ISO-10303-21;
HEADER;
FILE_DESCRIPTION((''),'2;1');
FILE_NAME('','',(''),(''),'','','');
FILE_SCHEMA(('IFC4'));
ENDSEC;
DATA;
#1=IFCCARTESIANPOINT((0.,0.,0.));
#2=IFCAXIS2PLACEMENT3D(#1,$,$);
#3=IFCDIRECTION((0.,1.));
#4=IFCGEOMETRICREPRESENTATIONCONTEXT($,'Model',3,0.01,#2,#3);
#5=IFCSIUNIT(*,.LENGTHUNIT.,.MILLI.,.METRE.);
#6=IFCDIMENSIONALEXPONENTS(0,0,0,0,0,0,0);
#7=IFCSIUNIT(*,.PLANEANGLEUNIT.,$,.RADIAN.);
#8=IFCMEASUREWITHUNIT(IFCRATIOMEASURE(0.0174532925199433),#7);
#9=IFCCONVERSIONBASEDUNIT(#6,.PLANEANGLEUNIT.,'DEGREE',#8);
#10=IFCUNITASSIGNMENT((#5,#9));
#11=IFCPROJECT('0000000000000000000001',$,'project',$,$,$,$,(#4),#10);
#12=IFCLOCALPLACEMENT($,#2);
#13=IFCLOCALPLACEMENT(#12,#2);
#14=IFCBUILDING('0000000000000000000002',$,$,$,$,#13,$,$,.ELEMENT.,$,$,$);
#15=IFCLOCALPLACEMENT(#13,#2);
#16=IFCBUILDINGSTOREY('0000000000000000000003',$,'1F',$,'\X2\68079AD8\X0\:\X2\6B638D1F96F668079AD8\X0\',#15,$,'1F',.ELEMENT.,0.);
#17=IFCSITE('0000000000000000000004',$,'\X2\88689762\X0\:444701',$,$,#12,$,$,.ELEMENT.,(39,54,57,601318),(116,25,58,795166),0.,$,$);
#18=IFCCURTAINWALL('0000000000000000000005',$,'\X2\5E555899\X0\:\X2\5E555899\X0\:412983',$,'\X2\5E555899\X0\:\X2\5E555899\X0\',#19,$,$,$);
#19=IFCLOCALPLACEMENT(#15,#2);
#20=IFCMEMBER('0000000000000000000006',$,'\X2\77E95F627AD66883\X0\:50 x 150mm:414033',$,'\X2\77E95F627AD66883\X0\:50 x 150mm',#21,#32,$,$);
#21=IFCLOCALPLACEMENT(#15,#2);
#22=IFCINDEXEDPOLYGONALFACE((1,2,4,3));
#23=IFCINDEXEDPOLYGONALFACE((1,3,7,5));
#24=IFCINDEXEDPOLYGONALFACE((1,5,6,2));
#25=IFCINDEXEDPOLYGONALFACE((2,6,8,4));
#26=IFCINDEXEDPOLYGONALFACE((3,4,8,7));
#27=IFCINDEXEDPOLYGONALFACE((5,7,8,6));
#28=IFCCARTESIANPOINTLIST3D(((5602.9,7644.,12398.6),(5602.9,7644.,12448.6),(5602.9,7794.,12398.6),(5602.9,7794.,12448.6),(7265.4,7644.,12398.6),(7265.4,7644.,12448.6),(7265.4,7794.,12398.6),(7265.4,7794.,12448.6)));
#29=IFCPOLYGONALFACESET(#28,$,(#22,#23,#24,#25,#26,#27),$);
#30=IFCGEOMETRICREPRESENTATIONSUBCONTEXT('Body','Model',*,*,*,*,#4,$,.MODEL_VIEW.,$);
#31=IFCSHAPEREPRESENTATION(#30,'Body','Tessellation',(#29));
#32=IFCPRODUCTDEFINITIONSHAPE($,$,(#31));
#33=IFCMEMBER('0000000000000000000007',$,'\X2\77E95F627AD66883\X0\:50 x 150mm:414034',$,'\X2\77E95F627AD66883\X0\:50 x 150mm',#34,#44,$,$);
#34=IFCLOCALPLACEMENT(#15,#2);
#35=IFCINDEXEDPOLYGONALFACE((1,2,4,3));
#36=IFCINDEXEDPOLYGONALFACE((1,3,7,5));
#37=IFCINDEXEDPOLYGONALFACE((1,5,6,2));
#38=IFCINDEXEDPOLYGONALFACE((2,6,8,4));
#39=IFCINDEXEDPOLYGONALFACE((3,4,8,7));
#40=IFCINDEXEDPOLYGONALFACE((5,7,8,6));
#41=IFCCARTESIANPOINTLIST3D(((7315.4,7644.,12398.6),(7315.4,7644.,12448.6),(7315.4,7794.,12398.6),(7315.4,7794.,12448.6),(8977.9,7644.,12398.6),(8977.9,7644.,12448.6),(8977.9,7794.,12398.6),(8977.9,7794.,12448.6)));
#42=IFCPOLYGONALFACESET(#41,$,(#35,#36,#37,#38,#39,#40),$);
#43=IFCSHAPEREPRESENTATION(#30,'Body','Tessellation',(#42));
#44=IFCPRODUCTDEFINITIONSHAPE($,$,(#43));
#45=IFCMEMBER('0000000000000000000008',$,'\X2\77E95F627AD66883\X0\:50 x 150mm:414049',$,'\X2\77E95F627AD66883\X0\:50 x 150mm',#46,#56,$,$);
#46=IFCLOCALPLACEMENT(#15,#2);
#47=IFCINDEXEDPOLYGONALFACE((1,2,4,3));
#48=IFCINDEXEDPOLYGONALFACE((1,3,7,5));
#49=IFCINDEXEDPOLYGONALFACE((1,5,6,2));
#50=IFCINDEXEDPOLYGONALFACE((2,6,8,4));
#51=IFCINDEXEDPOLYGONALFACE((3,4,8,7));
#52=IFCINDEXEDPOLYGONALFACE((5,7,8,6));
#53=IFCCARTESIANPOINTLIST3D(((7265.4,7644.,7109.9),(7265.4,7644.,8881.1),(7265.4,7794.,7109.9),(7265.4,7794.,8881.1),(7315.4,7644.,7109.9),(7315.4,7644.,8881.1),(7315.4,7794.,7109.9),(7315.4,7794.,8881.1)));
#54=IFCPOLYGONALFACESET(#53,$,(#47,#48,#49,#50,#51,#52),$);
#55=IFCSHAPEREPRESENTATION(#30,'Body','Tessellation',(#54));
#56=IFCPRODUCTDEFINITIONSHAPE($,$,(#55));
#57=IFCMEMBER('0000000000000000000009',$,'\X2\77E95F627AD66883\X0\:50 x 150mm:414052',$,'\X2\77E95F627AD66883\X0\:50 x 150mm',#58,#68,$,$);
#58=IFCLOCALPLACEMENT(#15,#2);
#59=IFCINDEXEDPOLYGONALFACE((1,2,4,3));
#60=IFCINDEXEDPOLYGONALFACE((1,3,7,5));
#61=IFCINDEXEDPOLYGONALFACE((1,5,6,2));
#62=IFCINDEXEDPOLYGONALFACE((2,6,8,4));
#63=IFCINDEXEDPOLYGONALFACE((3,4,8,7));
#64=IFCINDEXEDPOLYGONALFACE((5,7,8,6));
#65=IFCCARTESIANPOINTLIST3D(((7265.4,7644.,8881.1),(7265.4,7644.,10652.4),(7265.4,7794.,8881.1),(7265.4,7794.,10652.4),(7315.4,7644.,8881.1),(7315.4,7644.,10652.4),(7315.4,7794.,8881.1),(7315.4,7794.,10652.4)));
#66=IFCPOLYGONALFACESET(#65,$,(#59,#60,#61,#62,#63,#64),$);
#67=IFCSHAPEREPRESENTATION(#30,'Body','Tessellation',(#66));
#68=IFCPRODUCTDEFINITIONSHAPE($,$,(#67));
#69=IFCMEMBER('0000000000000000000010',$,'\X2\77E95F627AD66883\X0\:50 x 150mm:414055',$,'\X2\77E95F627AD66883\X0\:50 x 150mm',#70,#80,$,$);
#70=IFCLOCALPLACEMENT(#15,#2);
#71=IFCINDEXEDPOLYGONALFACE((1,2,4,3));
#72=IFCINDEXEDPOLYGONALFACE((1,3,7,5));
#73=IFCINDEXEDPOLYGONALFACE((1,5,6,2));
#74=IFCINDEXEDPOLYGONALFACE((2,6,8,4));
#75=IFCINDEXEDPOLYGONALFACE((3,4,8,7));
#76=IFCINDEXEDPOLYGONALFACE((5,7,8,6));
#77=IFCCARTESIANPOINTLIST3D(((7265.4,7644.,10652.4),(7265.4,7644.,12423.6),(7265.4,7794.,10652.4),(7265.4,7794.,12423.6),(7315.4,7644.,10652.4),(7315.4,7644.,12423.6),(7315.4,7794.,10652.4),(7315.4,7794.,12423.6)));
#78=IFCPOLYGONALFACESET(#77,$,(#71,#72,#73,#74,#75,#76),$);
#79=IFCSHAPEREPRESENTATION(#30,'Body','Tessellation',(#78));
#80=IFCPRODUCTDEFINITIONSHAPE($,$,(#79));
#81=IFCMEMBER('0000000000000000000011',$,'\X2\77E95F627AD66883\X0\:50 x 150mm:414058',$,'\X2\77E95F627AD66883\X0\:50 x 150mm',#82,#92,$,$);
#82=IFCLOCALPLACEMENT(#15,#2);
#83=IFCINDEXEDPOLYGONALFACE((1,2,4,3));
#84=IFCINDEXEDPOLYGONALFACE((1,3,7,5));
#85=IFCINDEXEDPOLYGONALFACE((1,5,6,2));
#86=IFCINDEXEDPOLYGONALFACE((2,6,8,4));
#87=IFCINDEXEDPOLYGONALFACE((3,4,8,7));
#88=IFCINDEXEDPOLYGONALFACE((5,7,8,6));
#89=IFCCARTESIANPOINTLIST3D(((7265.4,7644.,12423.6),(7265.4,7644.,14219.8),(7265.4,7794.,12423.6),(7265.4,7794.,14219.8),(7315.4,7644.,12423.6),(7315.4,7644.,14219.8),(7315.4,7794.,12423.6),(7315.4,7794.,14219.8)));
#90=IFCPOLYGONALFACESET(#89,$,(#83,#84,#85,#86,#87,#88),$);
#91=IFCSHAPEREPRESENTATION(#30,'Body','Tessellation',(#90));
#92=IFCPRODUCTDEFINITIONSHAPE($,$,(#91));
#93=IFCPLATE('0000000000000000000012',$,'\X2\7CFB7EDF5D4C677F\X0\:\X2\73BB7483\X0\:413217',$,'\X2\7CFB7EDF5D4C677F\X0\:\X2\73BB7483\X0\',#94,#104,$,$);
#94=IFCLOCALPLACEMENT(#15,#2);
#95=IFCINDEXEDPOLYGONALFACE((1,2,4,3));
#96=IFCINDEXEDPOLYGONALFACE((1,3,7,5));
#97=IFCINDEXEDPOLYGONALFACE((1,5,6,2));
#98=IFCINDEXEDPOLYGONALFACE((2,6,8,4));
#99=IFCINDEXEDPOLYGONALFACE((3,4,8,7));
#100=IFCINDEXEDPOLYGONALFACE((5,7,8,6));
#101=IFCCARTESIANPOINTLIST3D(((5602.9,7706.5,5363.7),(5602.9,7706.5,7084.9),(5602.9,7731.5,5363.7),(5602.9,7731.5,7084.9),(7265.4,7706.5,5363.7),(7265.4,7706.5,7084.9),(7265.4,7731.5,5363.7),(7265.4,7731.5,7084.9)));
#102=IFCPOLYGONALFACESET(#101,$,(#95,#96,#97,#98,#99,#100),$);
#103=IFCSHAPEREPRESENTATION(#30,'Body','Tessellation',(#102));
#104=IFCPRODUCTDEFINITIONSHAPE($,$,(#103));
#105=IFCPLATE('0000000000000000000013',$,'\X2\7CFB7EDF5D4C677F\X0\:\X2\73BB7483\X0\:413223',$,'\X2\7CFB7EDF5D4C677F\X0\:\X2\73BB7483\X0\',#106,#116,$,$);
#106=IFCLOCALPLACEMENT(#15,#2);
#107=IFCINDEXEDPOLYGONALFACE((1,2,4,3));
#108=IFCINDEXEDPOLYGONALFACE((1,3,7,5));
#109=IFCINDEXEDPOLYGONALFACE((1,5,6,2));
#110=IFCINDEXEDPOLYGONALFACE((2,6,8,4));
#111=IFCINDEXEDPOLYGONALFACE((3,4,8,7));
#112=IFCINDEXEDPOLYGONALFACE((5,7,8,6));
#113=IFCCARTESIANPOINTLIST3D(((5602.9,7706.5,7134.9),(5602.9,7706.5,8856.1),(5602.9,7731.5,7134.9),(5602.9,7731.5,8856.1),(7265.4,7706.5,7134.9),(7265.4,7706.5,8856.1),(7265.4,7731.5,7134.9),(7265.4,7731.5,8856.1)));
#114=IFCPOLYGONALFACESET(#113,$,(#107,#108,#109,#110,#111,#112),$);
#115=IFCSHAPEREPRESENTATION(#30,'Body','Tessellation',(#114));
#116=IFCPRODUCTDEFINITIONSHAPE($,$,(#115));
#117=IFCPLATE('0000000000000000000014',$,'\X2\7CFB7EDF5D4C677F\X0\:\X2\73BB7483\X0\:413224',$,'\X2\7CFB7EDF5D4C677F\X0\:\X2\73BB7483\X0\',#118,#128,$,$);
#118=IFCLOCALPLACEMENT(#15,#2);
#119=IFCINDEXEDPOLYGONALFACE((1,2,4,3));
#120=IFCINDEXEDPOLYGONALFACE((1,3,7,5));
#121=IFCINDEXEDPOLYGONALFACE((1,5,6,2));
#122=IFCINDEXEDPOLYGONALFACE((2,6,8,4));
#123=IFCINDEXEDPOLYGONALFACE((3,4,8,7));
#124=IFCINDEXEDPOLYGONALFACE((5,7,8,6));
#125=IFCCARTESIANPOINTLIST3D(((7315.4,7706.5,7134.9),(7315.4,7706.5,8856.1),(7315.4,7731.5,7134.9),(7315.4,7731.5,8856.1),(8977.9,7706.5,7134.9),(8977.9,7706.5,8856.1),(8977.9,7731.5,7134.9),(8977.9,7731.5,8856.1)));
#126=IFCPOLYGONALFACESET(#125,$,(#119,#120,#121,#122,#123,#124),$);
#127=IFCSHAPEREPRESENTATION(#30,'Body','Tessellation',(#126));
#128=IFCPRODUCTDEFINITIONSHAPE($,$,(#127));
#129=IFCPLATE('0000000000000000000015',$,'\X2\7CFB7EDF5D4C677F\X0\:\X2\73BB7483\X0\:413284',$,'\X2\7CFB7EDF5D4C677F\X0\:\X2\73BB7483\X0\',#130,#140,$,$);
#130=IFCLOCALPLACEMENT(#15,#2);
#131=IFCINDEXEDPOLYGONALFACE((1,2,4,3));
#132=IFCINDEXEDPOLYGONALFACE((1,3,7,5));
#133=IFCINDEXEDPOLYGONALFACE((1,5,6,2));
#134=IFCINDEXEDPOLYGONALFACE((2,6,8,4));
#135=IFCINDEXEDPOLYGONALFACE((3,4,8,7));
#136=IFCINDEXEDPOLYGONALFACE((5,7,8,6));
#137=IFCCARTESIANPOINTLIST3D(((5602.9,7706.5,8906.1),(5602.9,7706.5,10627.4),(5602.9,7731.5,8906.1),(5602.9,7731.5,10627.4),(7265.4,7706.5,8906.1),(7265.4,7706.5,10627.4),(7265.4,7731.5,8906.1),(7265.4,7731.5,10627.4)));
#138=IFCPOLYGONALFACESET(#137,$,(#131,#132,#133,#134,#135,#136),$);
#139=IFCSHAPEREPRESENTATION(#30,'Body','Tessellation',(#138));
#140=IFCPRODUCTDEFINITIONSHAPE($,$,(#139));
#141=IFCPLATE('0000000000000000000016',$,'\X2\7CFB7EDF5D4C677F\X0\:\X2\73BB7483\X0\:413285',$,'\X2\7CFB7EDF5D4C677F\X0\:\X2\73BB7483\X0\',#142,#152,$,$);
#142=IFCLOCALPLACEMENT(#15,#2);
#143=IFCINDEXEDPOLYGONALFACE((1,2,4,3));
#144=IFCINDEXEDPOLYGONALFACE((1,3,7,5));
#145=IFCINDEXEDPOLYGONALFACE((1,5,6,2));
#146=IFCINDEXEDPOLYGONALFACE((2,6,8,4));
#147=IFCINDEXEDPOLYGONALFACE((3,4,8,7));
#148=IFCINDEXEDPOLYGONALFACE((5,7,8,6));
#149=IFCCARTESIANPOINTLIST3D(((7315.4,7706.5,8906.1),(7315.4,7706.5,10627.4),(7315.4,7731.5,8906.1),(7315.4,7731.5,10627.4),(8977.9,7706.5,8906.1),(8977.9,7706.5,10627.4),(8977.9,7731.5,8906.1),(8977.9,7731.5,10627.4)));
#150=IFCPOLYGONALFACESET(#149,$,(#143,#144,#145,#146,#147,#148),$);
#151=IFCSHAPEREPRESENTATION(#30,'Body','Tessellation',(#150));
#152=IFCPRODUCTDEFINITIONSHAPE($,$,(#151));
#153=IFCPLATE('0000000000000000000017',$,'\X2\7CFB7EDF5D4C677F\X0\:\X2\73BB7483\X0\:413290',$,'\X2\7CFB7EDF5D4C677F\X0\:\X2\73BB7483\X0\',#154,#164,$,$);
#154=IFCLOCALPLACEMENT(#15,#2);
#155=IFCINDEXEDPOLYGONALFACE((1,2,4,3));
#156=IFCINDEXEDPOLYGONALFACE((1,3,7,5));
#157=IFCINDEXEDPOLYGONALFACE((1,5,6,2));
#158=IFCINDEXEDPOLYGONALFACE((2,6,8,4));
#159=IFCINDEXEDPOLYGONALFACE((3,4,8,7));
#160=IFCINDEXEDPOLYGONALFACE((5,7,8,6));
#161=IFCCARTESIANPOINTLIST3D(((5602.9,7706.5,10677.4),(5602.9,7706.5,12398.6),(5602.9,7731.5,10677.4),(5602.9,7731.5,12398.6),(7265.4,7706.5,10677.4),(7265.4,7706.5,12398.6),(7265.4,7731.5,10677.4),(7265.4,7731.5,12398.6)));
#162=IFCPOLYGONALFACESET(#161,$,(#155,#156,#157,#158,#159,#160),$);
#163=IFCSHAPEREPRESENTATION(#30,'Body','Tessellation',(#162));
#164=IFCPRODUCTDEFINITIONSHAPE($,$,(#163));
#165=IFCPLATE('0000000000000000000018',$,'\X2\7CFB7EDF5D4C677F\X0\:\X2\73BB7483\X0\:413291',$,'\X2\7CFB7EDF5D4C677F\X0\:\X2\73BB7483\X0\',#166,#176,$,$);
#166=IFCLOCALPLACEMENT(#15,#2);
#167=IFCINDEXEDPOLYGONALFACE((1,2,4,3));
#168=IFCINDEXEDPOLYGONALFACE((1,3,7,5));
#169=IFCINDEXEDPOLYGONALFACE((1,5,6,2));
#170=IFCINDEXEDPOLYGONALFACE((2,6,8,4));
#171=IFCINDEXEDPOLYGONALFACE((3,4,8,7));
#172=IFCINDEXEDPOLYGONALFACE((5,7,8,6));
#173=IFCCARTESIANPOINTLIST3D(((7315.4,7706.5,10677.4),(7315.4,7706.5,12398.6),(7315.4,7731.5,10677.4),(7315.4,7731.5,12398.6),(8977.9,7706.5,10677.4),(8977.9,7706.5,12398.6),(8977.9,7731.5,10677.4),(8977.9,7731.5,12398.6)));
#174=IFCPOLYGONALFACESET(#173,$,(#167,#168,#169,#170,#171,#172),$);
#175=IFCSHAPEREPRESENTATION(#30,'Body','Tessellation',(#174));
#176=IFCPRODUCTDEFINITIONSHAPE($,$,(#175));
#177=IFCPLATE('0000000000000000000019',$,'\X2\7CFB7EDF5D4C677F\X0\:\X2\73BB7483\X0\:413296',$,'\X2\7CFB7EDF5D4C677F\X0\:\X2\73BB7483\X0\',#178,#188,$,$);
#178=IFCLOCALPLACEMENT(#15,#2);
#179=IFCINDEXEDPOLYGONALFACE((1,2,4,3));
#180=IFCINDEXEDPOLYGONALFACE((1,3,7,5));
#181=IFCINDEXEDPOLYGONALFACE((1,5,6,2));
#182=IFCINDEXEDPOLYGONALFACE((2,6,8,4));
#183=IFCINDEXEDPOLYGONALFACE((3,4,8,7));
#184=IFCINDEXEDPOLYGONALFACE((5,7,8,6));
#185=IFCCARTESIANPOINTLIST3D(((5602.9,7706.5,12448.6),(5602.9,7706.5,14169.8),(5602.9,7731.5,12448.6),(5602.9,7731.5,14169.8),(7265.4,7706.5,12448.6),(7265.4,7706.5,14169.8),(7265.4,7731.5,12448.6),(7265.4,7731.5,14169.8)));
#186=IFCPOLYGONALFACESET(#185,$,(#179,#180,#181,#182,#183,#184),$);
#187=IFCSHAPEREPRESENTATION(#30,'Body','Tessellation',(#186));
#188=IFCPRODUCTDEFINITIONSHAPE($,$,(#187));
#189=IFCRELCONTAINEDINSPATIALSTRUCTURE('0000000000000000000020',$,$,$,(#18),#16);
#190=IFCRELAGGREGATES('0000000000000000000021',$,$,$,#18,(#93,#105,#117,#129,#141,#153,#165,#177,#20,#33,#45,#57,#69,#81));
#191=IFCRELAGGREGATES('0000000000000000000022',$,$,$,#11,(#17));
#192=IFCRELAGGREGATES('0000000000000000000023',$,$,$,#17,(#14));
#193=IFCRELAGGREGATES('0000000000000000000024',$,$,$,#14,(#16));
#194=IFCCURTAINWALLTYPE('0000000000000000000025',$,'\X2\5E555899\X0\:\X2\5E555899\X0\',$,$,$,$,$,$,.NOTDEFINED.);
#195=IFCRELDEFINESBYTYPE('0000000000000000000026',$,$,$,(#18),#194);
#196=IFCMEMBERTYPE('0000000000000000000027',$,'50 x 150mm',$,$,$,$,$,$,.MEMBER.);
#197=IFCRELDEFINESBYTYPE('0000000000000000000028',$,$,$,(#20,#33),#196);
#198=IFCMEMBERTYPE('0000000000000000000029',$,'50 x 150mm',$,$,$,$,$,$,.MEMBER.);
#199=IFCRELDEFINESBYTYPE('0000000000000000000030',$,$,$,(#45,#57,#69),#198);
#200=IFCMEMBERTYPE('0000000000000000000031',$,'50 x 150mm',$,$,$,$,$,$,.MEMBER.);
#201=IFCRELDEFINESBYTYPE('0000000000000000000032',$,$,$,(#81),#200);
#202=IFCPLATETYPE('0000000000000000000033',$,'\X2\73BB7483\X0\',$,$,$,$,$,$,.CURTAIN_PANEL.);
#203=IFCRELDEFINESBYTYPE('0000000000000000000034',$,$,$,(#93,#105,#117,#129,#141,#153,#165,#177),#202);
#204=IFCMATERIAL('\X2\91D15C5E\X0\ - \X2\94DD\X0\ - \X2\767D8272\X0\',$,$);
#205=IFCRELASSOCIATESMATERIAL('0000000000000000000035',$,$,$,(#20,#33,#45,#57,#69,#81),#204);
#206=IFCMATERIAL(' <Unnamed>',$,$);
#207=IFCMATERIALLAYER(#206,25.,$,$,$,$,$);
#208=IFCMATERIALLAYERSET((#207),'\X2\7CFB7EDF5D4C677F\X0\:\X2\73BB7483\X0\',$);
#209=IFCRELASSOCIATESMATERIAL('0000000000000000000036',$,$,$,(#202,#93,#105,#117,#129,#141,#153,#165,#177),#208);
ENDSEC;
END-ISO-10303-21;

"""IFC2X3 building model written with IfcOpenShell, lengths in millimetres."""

from ifc_helpers import new_model, entity, si_unit, converted_unit, direction, frame, origin, origin_2d_with_axis, place, context, subcontext, project, spatial, rectangle, extrude, source, transform, mapped, material, layer, layer_set, layer_usage, type_object, type_shapes, element, aggregate, save


model = new_model("IFC2X3")

# Units and contexts
model_context = context("Model", 3, precision=0.01, world=origin(), true_north=direction((0.0, 1.0)))
body_context = subcontext(model_context, "Body", "Model", "MODEL_VIEW")
ifc_project = project(units=[si_unit("LENGTHUNIT", "METRE", prefix="MILLI"), converted_unit("PLANEANGLEUNIT", "DEGREE", entity("IfcRatioMeasure", 0.0174532925199433), si_unit("PLANEANGLEUNIT", "RADIAN"), dimensions=[0, 0, 0, 0, 0, 0, 0])], contexts=[model_context])

# Site, building, storey
site_placement = place(None, origin())
site = spatial("IfcSite", under=ifc_project, at=site_placement, Name="表面:444701", CompositionType="ELEMENT", RefLatitude=(39, 54, 57, 601318), RefLongitude=(116, 25, 58, 795166), RefElevation=0.0)
building_placement = place(site_placement, origin())
building = spatial("IfcBuilding", under=site, at=building_placement, CompositionType="ELEMENT")
storey_placement = place(building_placement, origin())
storey = spatial("IfcBuildingStorey", under=building, at=storey_placement, Name="1F", ObjectType="标高:正负零标高", LongName="1F", CompositionType="ELEMENT", Elevation=0.0)

# Shared definitions
curtain_wall_type = type_object("IfcCurtainWallType", Name="幕墙:幕墙", PredefinedType="NOTDEFINED")
ifc_material_1 = material(Name="金属 - 铝 - 白色")

# Curtain wall, members, plates
curtain_wall_1_placement = place(storey_placement, origin())
curtain_wall_1 = element("IfcCurtainWall", 1, at=curtain_wall_1_placement, inside=storey, type_object=curtain_wall_type, Name="幕墙:幕墙:412983", ObjectType="幕墙:幕墙")
member_type_1 = type_object("IfcMemberType", Name="50 x 150mm", PredefinedType="MEMBER")
shared_shape_1 = source(origin(), body_context, "Body", "SweptSolid", [
    extrude(rectangle(XDim=150.0, YDim=50.0, at=origin_2d_with_axis()), frame((0.0, 0.0, -1662.5), z_axis=(0.0, 0.0, 1.0), x_axis=(0.0, -1.0, 0.0)), (0.0, 0.0, 1.0), 1662.5),
])
type_shapes(member_type_1, [shared_shape_1])
member_1_placement = place(storey_placement, frame((7265.4, 7719.0, 12423.6), z_axis=(1.0, 0.0, 0.0), x_axis=(0.0, 0.0, 1.0)))
member_1 = element("IfcMember", 2, at=member_1_placement, type_object=member_type_1, material=ifc_material_1, Name="矩形竖梃:50 x 150mm:414033", ObjectType="矩形竖梃:50 x 150mm", context=body_context, shape_type="MappedRepresentation", body=[
    mapped(shared_shape_1, transform((0.0, 0.0, 0.0), scale=1.0)),
])
member_2_placement = place(storey_placement, frame((8977.9, 7719.0, 12423.6), z_axis=(1.0, 0.0, 0.0), x_axis=(0.0, 0.0, 1.0)))
member_2 = element("IfcMember", 3, at=member_2_placement, type_object=member_type_1, material=ifc_material_1, Name="矩形竖梃:50 x 150mm:414034", ObjectType="矩形竖梃:50 x 150mm", context=body_context, shape_type="MappedRepresentation", body=[
    mapped(shared_shape_1, transform((0.0, 0.0, 0.0), scale=1.0)),
])
member_type_2 = type_object("IfcMemberType", Name="50 x 150mm", PredefinedType="MEMBER")
shared_shape_2 = source(origin(), body_context, "Body", "SweptSolid", [
    extrude(rectangle(XDim=150.0, YDim=50.0, at=origin_2d_with_axis()), frame((0.0, 0.0, -1771.2), z_axis=(0.0, 0.0, 1.0), x_axis=(0.0, -1.0, 0.0)), (0.0, 0.0, 1.0), 1771.2),
])
type_shapes(member_type_2, [shared_shape_2])
member_3_placement = place(storey_placement, frame((7290.4, 7719.0, 7109.9), z_axis=(0.0, 0.0, -1.0), x_axis=(1.0, 0.0, 0.0)))
member_3 = element("IfcMember", 4, at=member_3_placement, type_object=member_type_2, material=ifc_material_1, Name="矩形竖梃:50 x 150mm:414049", ObjectType="矩形竖梃:50 x 150mm", context=body_context, shape_type="MappedRepresentation", body=[
    mapped(shared_shape_2, transform((0.0, 0.0, 0.0), scale=1.0)),
])
member_4_placement = place(storey_placement, frame((7290.4, 7719.0, 8881.1), z_axis=(0.0, 0.0, -1.0), x_axis=(1.0, 0.0, 0.0)))
member_4 = element("IfcMember", 5, at=member_4_placement, type_object=member_type_2, material=ifc_material_1, Name="矩形竖梃:50 x 150mm:414052", ObjectType="矩形竖梃:50 x 150mm", context=body_context, shape_type="MappedRepresentation", body=[
    mapped(shared_shape_2, transform((0.0, 0.0, 0.0), scale=1.0)),
])
member_5_placement = place(storey_placement, frame((7290.4, 7719.0, 10652.4), z_axis=(0.0, 0.0, -1.0), x_axis=(1.0, 0.0, 0.0)))
member_5 = element("IfcMember", 6, at=member_5_placement, type_object=member_type_2, material=ifc_material_1, Name="矩形竖梃:50 x 150mm:414055", ObjectType="矩形竖梃:50 x 150mm", context=body_context, shape_type="MappedRepresentation", body=[
    mapped(shared_shape_2, transform((0.0, 0.0, 0.0), scale=1.0)),
])
member_type_3 = type_object("IfcMemberType", Name="50 x 150mm", PredefinedType="MEMBER")
shared_shape_3 = source(origin(), body_context, "Body", "SweptSolid", [
    extrude(rectangle(XDim=150.0, YDim=50.0, at=origin_2d_with_axis()), frame((0.0, 0.0, -1796.2), z_axis=(0.0, 0.0, 1.0), x_axis=(0.0, -1.0, 0.0)), (0.0, 0.0, 1.0), 1796.2),
])
type_shapes(member_type_3, [shared_shape_3])
member_6_placement = place(storey_placement, frame((7290.4, 7719.0, 12423.6), z_axis=(0.0, 0.0, -1.0), x_axis=(1.0, 0.0, 0.0)))
member_6 = element("IfcMember", 7, at=member_6_placement, type_object=member_type_3, material=ifc_material_1, Name="矩形竖梃:50 x 150mm:414058", ObjectType="矩形竖梃:50 x 150mm", context=body_context, shape_type="MappedRepresentation", body=[
    mapped(shared_shape_3, transform((0.0, 0.0, 0.0), scale=1.0)),
])
ifc_material_2 = material(Name=" <Unnamed>")
ifc_layer = layer(ifc_material_2, 25.0)
ifc_layer_set = layer_set([ifc_layer], Name="系统嵌板:玻璃")
ifc_layer_usage_1 = layer_usage(ifc_layer_set, "AXIS3", "POSITIVE", 0.0)
plate_type = type_object("IfcPlateType", Name="玻璃", PredefinedType="CURTAIN_PANEL", material=ifc_layer_set)
shared_shape_4 = source(origin(), body_context, "Body", "SweptSolid", [
    extrude(rectangle(XDim=25.0, YDim=1662.5, at=origin_2d_with_axis()), frame((0.0, 0.0, 0.0), z_axis=(0.0, 0.0, 1.0), x_axis=(0.0, 1.0, 0.0)), (0.0, 0.0, 1.0), 1721.2),
])
type_shapes(plate_type, [shared_shape_4])
plate_1_placement = place(curtain_wall_1_placement, frame((6434.2, 7719.0, 5363.7)))
plate_1 = element("IfcPlate", 8, at=plate_1_placement, type_object=plate_type, material=ifc_layer_usage_1, Name="系统嵌板:玻璃:413217", ObjectType="系统嵌板:玻璃", context=body_context, shape_type="MappedRepresentation", body=[
    mapped(shared_shape_4, transform((0.0, 0.0, 0.0), scale=1.0)),
])
ifc_layer_usage_2 = layer_usage(ifc_layer_set, "AXIS3", "POSITIVE", 0.0)
plate_2_placement = place(curtain_wall_1_placement, frame((6434.2, 7719.0, 7134.9)))
plate_2 = element("IfcPlate", 9, at=plate_2_placement, type_object=plate_type, material=ifc_layer_usage_2, Name="系统嵌板:玻璃:413223", ObjectType="系统嵌板:玻璃", context=body_context, shape_type="MappedRepresentation", body=[
    mapped(shared_shape_4, transform((0.0, 0.0, 0.0), scale=1.0)),
])
ifc_layer_usage_3 = layer_usage(ifc_layer_set, "AXIS3", "POSITIVE", 0.0)
plate_3_placement = place(curtain_wall_1_placement, frame((8146.7, 7719.0, 7134.9)))
plate_3 = element("IfcPlate", 10, at=plate_3_placement, type_object=plate_type, material=ifc_layer_usage_3, Name="系统嵌板:玻璃:413224", ObjectType="系统嵌板:玻璃", context=body_context, shape_type="MappedRepresentation", body=[
    mapped(shared_shape_4, transform((0.0, 0.0, 0.0), scale=1.0)),
])
ifc_layer_usage_4 = layer_usage(ifc_layer_set, "AXIS3", "POSITIVE", 0.0)
plate_4_placement = place(curtain_wall_1_placement, frame((6434.2, 7719.0, 8906.1)))
plate_4 = element("IfcPlate", 11, at=plate_4_placement, type_object=plate_type, material=ifc_layer_usage_4, Name="系统嵌板:玻璃:413284", ObjectType="系统嵌板:玻璃", context=body_context, shape_type="MappedRepresentation", body=[
    mapped(shared_shape_4, transform((0.0, 0.0, 0.0), scale=1.0)),
])
ifc_layer_usage_5 = layer_usage(ifc_layer_set, "AXIS3", "POSITIVE", 0.0)
plate_5_placement = place(curtain_wall_1_placement, frame((8146.7, 7719.0, 8906.1)))
plate_5 = element("IfcPlate", 12, at=plate_5_placement, type_object=plate_type, material=ifc_layer_usage_5, Name="系统嵌板:玻璃:413285", ObjectType="系统嵌板:玻璃", context=body_context, shape_type="MappedRepresentation", body=[
    mapped(shared_shape_4, transform((0.0, 0.0, 0.0), scale=1.0)),
])
ifc_layer_usage_6 = layer_usage(ifc_layer_set, "AXIS3", "POSITIVE", 0.0)
plate_6_placement = place(curtain_wall_1_placement, frame((6434.2, 7719.0, 10677.4)))
plate_6 = element("IfcPlate", 13, at=plate_6_placement, type_object=plate_type, material=ifc_layer_usage_6, Name="系统嵌板:玻璃:413290", ObjectType="系统嵌板:玻璃", context=body_context, shape_type="MappedRepresentation", body=[
    mapped(shared_shape_4, transform((0.0, 0.0, 0.0), scale=1.0)),
])
ifc_layer_usage_7 = layer_usage(ifc_layer_set, "AXIS3", "POSITIVE", 0.0)
plate_7_placement = place(curtain_wall_1_placement, frame((8146.7, 7719.0, 10677.4)))
plate_7 = element("IfcPlate", 14, at=plate_7_placement, type_object=plate_type, material=ifc_layer_usage_7, Name="系统嵌板:玻璃:413291", ObjectType="系统嵌板:玻璃", context=body_context, shape_type="MappedRepresentation", body=[
    mapped(shared_shape_4, transform((0.0, 0.0, 0.0), scale=1.0)),
])
ifc_layer_usage_8 = layer_usage(ifc_layer_set, "AXIS3", "POSITIVE", 0.0)
plate_8_placement = place(curtain_wall_1_placement, frame((6434.2, 7719.0, 12448.6)))
plate_8 = element("IfcPlate", 15, at=plate_8_placement, type_object=plate_type, material=ifc_layer_usage_8, Name="系统嵌板:玻璃:413296", ObjectType="系统嵌板:玻璃", context=body_context, shape_type="MappedRepresentation", body=[
    mapped(shared_shape_4, transform((0.0, 0.0, 0.0), scale=1.0)),
])
aggregate(curtain_wall_1, [plate_1, plate_2, plate_3, plate_4, plate_5, plate_6, plate_7, plate_8, member_1, member_2, member_3, member_4, member_5, member_6])

save(model, "model.ifc")
